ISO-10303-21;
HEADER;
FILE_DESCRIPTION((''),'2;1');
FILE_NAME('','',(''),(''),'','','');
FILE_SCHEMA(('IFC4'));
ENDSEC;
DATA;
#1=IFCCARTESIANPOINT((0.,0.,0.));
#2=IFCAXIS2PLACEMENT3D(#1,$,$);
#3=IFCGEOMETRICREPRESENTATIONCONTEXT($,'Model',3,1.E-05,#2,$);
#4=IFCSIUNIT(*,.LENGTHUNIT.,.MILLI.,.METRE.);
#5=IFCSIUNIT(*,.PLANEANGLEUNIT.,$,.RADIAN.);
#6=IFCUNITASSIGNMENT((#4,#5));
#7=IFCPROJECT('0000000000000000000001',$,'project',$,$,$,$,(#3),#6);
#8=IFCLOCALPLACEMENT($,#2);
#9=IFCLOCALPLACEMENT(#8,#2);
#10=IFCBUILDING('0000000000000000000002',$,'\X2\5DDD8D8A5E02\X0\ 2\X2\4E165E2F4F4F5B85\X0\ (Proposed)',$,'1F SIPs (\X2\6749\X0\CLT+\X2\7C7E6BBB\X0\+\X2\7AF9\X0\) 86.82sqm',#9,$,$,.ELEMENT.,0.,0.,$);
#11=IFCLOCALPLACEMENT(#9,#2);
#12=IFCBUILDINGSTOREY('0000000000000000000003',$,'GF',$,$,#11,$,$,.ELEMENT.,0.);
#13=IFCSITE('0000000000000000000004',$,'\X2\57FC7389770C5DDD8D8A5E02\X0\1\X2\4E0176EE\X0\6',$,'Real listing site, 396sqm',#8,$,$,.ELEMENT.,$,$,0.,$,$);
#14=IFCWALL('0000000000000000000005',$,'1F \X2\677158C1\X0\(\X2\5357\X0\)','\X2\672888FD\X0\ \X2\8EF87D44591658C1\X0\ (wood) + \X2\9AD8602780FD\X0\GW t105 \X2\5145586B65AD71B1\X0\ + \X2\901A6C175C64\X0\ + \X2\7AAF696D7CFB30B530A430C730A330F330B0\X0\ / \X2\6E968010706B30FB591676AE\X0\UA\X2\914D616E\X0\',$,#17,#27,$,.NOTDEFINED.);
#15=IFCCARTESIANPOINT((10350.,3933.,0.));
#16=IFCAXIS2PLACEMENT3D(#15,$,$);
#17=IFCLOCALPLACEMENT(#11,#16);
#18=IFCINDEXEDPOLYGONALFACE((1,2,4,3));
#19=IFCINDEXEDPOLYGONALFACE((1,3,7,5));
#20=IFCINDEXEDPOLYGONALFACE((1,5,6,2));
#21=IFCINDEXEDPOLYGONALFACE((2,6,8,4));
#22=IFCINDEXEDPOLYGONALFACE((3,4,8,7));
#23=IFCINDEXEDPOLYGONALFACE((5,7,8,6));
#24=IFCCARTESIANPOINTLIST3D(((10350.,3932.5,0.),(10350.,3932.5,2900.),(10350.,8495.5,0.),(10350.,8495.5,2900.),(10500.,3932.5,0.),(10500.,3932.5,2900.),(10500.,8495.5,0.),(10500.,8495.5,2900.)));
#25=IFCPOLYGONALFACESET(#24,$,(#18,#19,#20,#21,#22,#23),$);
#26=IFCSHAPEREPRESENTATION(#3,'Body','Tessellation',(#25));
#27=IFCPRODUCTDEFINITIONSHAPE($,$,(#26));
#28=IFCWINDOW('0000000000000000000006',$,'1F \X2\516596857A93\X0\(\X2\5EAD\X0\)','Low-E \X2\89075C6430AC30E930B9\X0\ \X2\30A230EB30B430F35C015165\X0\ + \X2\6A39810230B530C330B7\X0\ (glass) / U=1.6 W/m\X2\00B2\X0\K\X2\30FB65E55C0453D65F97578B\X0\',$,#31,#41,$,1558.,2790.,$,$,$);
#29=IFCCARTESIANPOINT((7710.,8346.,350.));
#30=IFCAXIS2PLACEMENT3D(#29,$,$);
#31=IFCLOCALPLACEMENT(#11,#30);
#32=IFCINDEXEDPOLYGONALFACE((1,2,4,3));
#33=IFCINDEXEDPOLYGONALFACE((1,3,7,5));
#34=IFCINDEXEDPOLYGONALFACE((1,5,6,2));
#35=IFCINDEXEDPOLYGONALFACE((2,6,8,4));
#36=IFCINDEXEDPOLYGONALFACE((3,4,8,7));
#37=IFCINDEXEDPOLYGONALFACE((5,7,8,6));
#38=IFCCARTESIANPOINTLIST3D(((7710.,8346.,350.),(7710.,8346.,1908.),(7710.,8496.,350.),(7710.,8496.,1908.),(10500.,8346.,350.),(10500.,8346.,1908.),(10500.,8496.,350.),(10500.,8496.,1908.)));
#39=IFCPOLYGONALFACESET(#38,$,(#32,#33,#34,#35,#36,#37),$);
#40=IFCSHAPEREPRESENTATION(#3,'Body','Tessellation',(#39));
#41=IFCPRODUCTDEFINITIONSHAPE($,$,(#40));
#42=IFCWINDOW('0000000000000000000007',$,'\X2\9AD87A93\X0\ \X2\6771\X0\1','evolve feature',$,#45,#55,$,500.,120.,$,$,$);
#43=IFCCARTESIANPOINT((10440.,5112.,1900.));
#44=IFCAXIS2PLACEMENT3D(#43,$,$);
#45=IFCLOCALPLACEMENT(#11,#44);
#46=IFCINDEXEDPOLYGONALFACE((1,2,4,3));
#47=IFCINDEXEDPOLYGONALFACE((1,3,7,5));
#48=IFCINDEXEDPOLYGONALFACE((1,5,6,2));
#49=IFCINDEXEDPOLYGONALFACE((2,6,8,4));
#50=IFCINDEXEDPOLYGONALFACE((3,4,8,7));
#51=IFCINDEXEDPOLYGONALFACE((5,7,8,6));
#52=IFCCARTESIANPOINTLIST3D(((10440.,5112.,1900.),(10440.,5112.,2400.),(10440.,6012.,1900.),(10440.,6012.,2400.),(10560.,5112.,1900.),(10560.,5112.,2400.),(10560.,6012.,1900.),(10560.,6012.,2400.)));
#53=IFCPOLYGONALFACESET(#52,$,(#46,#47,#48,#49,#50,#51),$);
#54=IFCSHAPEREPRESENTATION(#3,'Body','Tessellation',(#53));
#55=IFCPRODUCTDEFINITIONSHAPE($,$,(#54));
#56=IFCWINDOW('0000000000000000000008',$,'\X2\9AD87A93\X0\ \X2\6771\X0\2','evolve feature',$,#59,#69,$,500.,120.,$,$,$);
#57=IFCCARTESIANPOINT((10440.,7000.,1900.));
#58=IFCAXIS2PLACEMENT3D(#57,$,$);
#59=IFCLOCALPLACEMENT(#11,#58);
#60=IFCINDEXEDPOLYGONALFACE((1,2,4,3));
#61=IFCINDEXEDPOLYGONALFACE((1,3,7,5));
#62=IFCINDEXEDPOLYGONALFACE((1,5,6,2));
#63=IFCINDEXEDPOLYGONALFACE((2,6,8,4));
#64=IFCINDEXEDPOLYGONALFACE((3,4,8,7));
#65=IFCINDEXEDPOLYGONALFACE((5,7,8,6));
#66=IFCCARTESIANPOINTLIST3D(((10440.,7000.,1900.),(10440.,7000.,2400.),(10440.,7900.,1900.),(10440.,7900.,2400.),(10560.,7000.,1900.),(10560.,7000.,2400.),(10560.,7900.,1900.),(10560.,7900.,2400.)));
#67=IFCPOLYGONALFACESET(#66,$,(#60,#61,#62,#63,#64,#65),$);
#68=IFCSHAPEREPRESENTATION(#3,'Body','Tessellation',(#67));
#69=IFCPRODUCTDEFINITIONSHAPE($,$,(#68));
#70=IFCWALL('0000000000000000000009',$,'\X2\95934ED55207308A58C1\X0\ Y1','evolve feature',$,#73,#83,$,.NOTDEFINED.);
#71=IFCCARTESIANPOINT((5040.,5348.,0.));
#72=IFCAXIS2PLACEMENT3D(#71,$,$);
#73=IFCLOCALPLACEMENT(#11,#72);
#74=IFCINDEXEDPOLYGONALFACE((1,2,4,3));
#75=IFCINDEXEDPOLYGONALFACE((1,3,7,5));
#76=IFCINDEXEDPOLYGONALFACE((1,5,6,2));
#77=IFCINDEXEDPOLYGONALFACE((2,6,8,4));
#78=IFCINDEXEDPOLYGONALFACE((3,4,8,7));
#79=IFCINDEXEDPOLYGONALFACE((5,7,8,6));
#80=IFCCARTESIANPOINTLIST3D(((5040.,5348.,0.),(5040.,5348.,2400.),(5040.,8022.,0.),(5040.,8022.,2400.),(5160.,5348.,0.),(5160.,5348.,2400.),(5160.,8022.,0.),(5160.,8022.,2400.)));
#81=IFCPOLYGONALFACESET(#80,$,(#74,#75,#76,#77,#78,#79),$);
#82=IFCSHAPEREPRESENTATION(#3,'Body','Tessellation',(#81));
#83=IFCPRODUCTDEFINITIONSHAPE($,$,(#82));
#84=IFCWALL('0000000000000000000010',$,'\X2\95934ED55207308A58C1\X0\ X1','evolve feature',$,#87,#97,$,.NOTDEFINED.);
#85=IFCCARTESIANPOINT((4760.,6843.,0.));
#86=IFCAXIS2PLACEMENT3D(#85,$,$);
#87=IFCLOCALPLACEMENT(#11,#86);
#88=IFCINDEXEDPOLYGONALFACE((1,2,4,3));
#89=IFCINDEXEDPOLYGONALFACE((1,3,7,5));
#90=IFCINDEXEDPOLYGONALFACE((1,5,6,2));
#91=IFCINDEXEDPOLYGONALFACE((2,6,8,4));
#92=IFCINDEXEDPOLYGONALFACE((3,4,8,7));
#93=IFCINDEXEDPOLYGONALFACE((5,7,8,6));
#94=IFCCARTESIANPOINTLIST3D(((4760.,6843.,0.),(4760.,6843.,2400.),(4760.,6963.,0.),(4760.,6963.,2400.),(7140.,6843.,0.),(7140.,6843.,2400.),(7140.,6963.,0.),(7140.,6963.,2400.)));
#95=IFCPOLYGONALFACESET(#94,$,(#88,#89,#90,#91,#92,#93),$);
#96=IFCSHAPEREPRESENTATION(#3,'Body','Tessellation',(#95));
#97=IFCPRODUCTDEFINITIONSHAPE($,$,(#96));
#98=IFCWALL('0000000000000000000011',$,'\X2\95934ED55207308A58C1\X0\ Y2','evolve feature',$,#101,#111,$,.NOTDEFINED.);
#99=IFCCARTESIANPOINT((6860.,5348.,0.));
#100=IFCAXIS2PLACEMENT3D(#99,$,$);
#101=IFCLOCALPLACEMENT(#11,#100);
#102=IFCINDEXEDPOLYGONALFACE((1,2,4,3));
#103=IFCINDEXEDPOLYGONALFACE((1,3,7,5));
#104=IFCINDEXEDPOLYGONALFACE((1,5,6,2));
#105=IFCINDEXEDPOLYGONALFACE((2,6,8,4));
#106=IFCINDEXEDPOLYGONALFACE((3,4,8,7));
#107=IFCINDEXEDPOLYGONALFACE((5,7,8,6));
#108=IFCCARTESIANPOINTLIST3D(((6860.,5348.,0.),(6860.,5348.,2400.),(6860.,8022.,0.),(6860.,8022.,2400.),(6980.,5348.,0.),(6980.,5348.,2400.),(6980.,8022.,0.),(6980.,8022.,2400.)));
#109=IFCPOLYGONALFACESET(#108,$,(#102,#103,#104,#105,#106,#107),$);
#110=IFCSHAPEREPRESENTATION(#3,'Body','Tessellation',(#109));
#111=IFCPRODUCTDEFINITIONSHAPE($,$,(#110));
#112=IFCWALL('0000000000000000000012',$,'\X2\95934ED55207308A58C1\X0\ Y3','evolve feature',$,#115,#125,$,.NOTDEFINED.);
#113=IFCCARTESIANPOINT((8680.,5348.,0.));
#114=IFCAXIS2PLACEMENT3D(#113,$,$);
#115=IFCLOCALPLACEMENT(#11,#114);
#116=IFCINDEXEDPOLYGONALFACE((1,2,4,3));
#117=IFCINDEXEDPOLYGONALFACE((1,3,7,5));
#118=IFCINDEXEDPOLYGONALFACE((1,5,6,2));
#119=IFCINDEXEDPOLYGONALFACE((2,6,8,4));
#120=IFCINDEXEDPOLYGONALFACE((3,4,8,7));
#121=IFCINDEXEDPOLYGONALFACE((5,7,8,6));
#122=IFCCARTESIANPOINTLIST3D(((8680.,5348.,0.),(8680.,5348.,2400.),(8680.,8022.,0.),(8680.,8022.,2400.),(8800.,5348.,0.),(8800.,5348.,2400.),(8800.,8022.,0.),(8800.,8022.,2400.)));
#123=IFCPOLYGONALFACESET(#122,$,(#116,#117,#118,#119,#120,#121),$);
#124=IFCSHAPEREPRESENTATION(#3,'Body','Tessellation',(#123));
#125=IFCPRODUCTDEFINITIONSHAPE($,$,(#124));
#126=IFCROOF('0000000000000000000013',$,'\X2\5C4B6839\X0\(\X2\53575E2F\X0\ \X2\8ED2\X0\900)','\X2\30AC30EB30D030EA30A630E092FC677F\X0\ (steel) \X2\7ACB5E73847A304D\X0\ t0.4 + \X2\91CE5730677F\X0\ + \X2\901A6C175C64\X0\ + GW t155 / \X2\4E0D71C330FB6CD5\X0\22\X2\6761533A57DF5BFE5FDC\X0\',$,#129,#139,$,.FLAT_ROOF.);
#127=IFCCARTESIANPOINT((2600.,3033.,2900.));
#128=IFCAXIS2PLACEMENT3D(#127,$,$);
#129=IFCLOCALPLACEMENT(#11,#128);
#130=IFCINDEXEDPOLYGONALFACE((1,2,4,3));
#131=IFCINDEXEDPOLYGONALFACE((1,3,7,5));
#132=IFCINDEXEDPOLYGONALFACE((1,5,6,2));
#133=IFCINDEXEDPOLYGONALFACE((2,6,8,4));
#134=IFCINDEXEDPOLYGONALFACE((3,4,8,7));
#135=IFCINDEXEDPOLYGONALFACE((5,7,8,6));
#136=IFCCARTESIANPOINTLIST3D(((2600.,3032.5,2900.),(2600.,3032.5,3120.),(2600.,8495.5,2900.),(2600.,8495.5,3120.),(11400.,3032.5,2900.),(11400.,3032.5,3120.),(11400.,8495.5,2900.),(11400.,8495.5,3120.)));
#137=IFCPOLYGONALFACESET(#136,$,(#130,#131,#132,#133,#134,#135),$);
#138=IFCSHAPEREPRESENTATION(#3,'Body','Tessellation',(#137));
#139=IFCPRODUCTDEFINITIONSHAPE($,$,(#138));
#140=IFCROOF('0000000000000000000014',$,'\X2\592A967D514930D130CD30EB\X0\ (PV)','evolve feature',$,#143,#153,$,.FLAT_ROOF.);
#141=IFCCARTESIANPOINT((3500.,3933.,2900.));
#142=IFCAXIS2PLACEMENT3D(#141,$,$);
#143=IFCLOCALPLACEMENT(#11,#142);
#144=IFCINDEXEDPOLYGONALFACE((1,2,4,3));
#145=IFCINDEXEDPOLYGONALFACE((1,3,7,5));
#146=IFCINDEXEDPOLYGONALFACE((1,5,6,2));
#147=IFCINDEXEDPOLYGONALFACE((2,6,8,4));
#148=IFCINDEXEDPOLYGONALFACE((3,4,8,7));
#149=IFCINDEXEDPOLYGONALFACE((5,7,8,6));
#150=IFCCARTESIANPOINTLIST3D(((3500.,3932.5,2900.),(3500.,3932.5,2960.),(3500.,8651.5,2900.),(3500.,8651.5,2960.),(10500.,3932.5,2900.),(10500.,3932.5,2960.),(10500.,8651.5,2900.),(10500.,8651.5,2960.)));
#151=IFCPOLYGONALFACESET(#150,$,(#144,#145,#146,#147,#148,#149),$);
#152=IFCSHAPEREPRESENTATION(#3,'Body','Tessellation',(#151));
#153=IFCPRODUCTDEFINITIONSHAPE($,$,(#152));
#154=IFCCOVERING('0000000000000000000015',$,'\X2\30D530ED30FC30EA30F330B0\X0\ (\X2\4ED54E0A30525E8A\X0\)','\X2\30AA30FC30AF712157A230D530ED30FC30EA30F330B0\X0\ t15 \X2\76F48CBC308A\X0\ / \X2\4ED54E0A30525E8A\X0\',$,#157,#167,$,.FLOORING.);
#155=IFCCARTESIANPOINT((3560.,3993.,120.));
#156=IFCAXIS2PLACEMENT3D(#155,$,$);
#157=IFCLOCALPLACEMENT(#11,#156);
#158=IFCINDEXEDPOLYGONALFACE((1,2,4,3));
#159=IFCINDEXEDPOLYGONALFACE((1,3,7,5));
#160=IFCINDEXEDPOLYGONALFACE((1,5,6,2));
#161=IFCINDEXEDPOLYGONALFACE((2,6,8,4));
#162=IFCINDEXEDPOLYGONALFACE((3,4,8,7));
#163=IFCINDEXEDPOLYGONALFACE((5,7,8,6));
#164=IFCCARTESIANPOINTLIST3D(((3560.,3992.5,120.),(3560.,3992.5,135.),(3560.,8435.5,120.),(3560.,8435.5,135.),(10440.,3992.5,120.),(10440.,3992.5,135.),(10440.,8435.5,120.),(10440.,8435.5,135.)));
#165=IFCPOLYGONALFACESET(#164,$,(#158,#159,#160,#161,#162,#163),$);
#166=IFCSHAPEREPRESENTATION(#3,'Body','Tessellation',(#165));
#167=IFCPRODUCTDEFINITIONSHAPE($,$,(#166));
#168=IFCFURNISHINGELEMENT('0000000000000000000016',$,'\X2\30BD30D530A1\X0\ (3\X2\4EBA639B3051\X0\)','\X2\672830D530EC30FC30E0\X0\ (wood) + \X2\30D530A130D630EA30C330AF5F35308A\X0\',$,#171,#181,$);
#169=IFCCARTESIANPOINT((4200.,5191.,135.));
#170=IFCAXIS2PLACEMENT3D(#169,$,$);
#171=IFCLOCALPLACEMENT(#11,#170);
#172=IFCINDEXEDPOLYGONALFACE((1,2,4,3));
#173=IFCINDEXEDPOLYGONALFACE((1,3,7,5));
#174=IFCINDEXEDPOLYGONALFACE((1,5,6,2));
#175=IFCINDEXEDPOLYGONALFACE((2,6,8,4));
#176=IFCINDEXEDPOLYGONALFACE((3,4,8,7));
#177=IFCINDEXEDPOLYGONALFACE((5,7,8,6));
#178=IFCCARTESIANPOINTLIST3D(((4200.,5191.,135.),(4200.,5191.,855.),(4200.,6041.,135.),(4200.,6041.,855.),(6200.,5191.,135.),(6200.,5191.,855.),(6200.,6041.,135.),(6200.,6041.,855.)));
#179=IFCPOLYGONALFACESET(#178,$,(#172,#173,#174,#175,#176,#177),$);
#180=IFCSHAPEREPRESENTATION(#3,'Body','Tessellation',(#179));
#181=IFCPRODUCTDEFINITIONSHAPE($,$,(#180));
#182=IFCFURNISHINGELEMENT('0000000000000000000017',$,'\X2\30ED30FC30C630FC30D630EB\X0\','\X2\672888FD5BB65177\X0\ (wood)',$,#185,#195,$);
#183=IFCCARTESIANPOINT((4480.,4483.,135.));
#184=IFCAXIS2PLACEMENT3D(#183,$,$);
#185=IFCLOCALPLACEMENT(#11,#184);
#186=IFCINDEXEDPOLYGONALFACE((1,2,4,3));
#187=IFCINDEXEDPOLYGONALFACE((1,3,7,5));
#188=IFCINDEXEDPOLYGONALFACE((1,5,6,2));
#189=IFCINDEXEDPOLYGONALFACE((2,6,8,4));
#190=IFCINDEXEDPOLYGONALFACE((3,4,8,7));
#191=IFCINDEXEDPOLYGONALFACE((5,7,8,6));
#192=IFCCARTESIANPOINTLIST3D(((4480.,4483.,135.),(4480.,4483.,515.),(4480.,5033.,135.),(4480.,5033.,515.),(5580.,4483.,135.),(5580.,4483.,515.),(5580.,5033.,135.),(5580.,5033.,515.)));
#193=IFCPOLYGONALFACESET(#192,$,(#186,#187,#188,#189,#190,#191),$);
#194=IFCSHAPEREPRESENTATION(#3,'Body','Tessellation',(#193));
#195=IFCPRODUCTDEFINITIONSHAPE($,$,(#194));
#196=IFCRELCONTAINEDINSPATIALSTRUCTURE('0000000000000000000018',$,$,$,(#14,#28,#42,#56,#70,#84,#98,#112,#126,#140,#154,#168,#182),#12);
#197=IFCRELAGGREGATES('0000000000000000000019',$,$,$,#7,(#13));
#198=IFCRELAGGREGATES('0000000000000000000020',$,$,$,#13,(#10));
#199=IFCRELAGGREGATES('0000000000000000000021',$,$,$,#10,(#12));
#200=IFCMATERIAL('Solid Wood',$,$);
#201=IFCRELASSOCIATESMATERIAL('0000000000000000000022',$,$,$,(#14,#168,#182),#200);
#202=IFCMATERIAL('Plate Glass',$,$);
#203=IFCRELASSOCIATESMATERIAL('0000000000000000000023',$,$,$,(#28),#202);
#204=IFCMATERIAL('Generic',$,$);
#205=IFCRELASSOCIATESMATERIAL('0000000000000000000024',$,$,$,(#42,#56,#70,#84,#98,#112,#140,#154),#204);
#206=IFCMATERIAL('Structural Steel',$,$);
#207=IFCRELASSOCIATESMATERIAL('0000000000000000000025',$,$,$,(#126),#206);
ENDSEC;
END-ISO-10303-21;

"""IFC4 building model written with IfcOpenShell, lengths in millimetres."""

from ifc_helpers import new_model, si_unit, frame, frame_2d, origin, place, context, project, spatial, rectangle, extrude, material, element, fill, save


model = new_model("IFC4")

# Units and contexts
model_context = context("Model", 3, precision=1e-05, world=origin())
ifc_project = project(units=[si_unit("LENGTHUNIT", "METRE", prefix="MILLI"), si_unit("PLANEANGLEUNIT", "RADIAN")], contexts=[model_context])

# Site, building, storey
site_placement = place(None, origin())
site = spatial("IfcSite", under=ifc_project, at=site_placement, Name="埼玉県川越市1丁目6", ObjectType="Real listing site, 396sqm", CompositionType="ELEMENT", RefElevation=0.0)
building_placement = place(site_placement, origin())
building = spatial("IfcBuilding", under=site, at=building_placement, Name="川越市 2世帯住宅 (Proposed)", ObjectType="1F SIPs (杉CLT+籾殻+竹) 86.82sqm", CompositionType="ELEMENT", ElevationOfRefHeight=0.0, ElevationOfTerrain=0.0)
storey_placement = place(building_placement, origin())
storey = spatial("IfcBuildingStorey", under=building, at=storey_placement, Name="GF", CompositionType="ELEMENT", Elevation=0.0)

# Shared definitions
ifc_material_1 = material(Name="Solid Wood")
ifc_material_2 = material(Name="Generic")

# Shared definitions
ifc_material_3 = material(Name="Plate Glass")

# Wall, openings, windows
wall_1_placement = place(storey_placement, frame((10350.0, 3933.0, 0.0)))
wall_1 = element("IfcWall", 1, at=wall_1_placement, inside=storey, material=ifc_material_1, Name="1F 東壁(南)", Description="木製 軸組外壁 (wood) + 高性能GW t105 充填断熱 + 通気層 + 窯業系サイディング / 準耐火・外皮UA配慮", PredefinedType="NOTDEFINED", context=model_context, shape_type="SweptSolid", body=[
    extrude(rectangle(XDim=150.0, YDim=4563.0, at=frame_2d((75.0, 2281.0))), frame((10350.0, 3933.0, 0.0)), (0.0, 0.0, 1.0), 2900.0),
])
opening_1_placement = place(storey_placement, frame((7710.0, 8346.0, 350.0)))
opening_1 = element("IfcOpeningElement", 2, at=opening_1_placement, cuts=wall_1, PredefinedType="NOTDEFINED", context=model_context, shape_type="SweptSolid", body=[
    extrude(rectangle(XDim=2790.0, YDim=150.0, at=frame_2d((1395.0, 75.0))), frame((7710.0, 8346.0, 350.0)), (0.0, 0.0, 1.0), 1558.0),
])
opening_2_placement = place(storey_placement, frame((10440.0, 5112.0, 1900.0)))
opening_2 = element("IfcOpeningElement", 3, at=opening_2_placement, cuts=wall_1, PredefinedType="NOTDEFINED", context=model_context, shape_type="SweptSolid", body=[
    extrude(rectangle(XDim=120.0, YDim=900.0, at=frame_2d((60.0, 450.0))), frame((10440.0, 5112.0, 1900.0)), (0.0, 0.0, 1.0), 500.0),
])
opening_3_placement = place(storey_placement, frame((10440.0, 7000.0, 1900.0)))
opening_3 = element("IfcOpeningElement", 4, at=opening_3_placement, cuts=wall_1, PredefinedType="NOTDEFINED", context=model_context, shape_type="SweptSolid", body=[
    extrude(rectangle(XDim=120.0, YDim=900.0, at=frame_2d((60.0, 450.0))), frame((10440.0, 7000.0, 1900.0)), (0.0, 0.0, 1.0), 500.0),
])
window_1_placement = place(storey_placement, frame((7710.0, 8346.0, 350.0)))
window_1 = element("IfcWindow", 5, at=window_1_placement, inside=storey, material=ifc_material_3, Name="1F 入隅窓(庭)", Description="Low-E 複層ガラス アルゴン封入 + 樹脂サッシ (glass) / U=1.6 W/m²K・日射取得型", OverallHeight=1558.0, OverallWidth=2790.0, context=model_context, shape_type="SweptSolid", body=[
    extrude(rectangle(XDim=2790.0, YDim=150.0, at=frame_2d((1395.0, 75.0))), frame((7710.0, 8346.0, 350.0)), (0.0, 0.0, 1.0), 1558.0),
])
fill(opening_1, window_1)
window_2_placement = place(storey_placement, frame((10440.0, 5112.0, 1900.0)))
window_2 = element("IfcWindow", 6, at=window_2_placement, inside=storey, material=ifc_material_2, Name="高窓 東1", Description="evolve feature", OverallHeight=500.0, OverallWidth=120.0, context=model_context, shape_type="SweptSolid", body=[
    extrude(rectangle(XDim=120.0, YDim=900.0, at=frame_2d((60.0, 450.0))), frame((10440.0, 5112.0, 1900.0)), (0.0, 0.0, 1.0), 500.0),
])
fill(opening_2, window_2)
window_3_placement = place(storey_placement, frame((10440.0, 7000.0, 1900.0)))
window_3 = element("IfcWindow", 7, at=window_3_placement, inside=storey, material=ifc_material_2, Name="高窓 東2", Description="evolve feature", OverallHeight=500.0, OverallWidth=120.0, context=model_context, shape_type="SweptSolid", body=[
    extrude(rectangle(XDim=120.0, YDim=900.0, at=frame_2d((60.0, 450.0))), frame((10440.0, 7000.0, 1900.0)), (0.0, 0.0, 1.0), 500.0),
])
fill(opening_3, window_3)

# Walls
wall_2_placement = place(storey_placement, frame((5040.0, 5348.0, 0.0)))
element("IfcWall", 8, at=wall_2_placement, inside=storey, material=ifc_material_2, Name="間仕切り壁 Y1", Description="evolve feature", PredefinedType="NOTDEFINED", context=model_context, shape_type="SweptSolid", body=[
    extrude(rectangle(XDim=120.0, YDim=2674.0, at=frame_2d((60.0, 1337.0))), frame((5040.0, 5348.0, 0.0)), (0.0, 0.0, 1.0), 2400.0),
])
wall_3_placement = place(storey_placement, frame((4760.0, 6843.0, 0.0)))
element("IfcWall", 9, at=wall_3_placement, inside=storey, material=ifc_material_2, Name="間仕切り壁 X1", Description="evolve feature", PredefinedType="NOTDEFINED", context=model_context, shape_type="SweptSolid", body=[
    extrude(rectangle(XDim=2380.0, YDim=120.0, at=frame_2d((1190.0, 60.0))), frame((4760.0, 6843.0, 0.0)), (0.0, 0.0, 1.0), 2400.0),
])
wall_4_placement = place(storey_placement, frame((6860.0, 5348.0, 0.0)))
element("IfcWall", 10, at=wall_4_placement, inside=storey, material=ifc_material_2, Name="間仕切り壁 Y2", Description="evolve feature", PredefinedType="NOTDEFINED", context=model_context, shape_type="SweptSolid", body=[
    extrude(rectangle(XDim=120.0, YDim=2674.0, at=frame_2d((60.0, 1337.0))), frame((6860.0, 5348.0, 0.0)), (0.0, 0.0, 1.0), 2400.0),
])
wall_5_placement = place(storey_placement, frame((8680.0, 5348.0, 0.0)))
element("IfcWall", 11, at=wall_5_placement, inside=storey, material=ifc_material_2, Name="間仕切り壁 Y3", Description="evolve feature", PredefinedType="NOTDEFINED", context=model_context, shape_type="SweptSolid", body=[
    extrude(rectangle(XDim=120.0, YDim=2674.0, at=frame_2d((60.0, 1337.0))), frame((8680.0, 5348.0, 0.0)), (0.0, 0.0, 1.0), 2400.0),
])

# Roofs
ifc_material_4 = material(Name="Structural Steel")
roof_1_placement = place(storey_placement, frame((2600.0, 3033.0, 2900.0)))
element("IfcRoof", 12, at=roof_1_placement, inside=storey, material=ifc_material_4, Name="屋根(南帯 軒900)", Description="ガルバリウム鋼板 (steel) 立平葺き t0.4 + 野地板 + 通気層 + GW t155 / 不燃・法22条区域対応", PredefinedType="FLAT_ROOF", context=model_context, shape_type="SweptSolid", body=[
    extrude(rectangle(XDim=8800.0, YDim=5463.0, at=frame_2d((4400.0, 2731.0))), frame((2600.0, 3033.0, 2900.0)), (0.0, 0.0, 1.0), 220.0),
])
roof_2_placement = place(storey_placement, frame((3500.0, 3933.0, 2900.0)))
element("IfcRoof", 13, at=roof_2_placement, inside=storey, material=ifc_material_2, Name="太陽光パネル (PV)", Description="evolve feature", PredefinedType="FLAT_ROOF", context=model_context, shape_type="SweptSolid", body=[
    extrude(rectangle(XDim=7000.0, YDim=4719.0, at=frame_2d((3500.0, 2359.0))), frame((3500.0, 3933.0, 2900.0)), (0.0, 0.0, 1.0), 60.0),
])

# Covering
covering_placement = place(storey_placement, frame((3560.0, 3993.0, 120.0)))
element("IfcCovering", 14, at=covering_placement, inside=storey, material=ifc_material_2, Name="フローリング (仕上げ床)", Description="オーク無垢フローリング t15 直貼り / 仕上げ床", PredefinedType="FLOORING", context=model_context, shape_type="SweptSolid", body=[
    extrude(rectangle(XDim=6880.0, YDim=4443.0, at=frame_2d((3440.0, 2221.0))), frame((3560.0, 3993.0, 120.0)), (0.0, 0.0, 1.0), 15.0),
])

# Furnishing elements
furnishing_1_placement = place(storey_placement, frame((4200.0, 5191.0, 135.0)))
element("IfcFurnishingElement", 15, at=furnishing_1_placement, inside=storey, material=ifc_material_1, Name="ソファ (3人掛け)", Description="木フレーム (wood) + ファブリック張り", context=model_context, shape_type="SweptSolid", body=[
    extrude(rectangle(XDim=2000.0, YDim=850.0, at=frame_2d((1000.0, 425.0))), frame((4200.0, 5191.0, 135.0)), (0.0, 0.0, 1.0), 720.0),
])
furnishing_2_placement = place(storey_placement, frame((4480.0, 4483.0, 135.0)))
element("IfcFurnishingElement", 16, at=furnishing_2_placement, inside=storey, material=ifc_material_1, Name="ローテーブル", Description="木製家具 (wood)", context=model_context, shape_type="SweptSolid", body=[
    extrude(rectangle(XDim=1100.0, YDim=550.0, at=frame_2d((550.0, 275.0))), frame((4480.0, 4483.0, 135.0)), (0.0, 0.0, 1.0), 380.0),
])

save(model, "model.ifc")
